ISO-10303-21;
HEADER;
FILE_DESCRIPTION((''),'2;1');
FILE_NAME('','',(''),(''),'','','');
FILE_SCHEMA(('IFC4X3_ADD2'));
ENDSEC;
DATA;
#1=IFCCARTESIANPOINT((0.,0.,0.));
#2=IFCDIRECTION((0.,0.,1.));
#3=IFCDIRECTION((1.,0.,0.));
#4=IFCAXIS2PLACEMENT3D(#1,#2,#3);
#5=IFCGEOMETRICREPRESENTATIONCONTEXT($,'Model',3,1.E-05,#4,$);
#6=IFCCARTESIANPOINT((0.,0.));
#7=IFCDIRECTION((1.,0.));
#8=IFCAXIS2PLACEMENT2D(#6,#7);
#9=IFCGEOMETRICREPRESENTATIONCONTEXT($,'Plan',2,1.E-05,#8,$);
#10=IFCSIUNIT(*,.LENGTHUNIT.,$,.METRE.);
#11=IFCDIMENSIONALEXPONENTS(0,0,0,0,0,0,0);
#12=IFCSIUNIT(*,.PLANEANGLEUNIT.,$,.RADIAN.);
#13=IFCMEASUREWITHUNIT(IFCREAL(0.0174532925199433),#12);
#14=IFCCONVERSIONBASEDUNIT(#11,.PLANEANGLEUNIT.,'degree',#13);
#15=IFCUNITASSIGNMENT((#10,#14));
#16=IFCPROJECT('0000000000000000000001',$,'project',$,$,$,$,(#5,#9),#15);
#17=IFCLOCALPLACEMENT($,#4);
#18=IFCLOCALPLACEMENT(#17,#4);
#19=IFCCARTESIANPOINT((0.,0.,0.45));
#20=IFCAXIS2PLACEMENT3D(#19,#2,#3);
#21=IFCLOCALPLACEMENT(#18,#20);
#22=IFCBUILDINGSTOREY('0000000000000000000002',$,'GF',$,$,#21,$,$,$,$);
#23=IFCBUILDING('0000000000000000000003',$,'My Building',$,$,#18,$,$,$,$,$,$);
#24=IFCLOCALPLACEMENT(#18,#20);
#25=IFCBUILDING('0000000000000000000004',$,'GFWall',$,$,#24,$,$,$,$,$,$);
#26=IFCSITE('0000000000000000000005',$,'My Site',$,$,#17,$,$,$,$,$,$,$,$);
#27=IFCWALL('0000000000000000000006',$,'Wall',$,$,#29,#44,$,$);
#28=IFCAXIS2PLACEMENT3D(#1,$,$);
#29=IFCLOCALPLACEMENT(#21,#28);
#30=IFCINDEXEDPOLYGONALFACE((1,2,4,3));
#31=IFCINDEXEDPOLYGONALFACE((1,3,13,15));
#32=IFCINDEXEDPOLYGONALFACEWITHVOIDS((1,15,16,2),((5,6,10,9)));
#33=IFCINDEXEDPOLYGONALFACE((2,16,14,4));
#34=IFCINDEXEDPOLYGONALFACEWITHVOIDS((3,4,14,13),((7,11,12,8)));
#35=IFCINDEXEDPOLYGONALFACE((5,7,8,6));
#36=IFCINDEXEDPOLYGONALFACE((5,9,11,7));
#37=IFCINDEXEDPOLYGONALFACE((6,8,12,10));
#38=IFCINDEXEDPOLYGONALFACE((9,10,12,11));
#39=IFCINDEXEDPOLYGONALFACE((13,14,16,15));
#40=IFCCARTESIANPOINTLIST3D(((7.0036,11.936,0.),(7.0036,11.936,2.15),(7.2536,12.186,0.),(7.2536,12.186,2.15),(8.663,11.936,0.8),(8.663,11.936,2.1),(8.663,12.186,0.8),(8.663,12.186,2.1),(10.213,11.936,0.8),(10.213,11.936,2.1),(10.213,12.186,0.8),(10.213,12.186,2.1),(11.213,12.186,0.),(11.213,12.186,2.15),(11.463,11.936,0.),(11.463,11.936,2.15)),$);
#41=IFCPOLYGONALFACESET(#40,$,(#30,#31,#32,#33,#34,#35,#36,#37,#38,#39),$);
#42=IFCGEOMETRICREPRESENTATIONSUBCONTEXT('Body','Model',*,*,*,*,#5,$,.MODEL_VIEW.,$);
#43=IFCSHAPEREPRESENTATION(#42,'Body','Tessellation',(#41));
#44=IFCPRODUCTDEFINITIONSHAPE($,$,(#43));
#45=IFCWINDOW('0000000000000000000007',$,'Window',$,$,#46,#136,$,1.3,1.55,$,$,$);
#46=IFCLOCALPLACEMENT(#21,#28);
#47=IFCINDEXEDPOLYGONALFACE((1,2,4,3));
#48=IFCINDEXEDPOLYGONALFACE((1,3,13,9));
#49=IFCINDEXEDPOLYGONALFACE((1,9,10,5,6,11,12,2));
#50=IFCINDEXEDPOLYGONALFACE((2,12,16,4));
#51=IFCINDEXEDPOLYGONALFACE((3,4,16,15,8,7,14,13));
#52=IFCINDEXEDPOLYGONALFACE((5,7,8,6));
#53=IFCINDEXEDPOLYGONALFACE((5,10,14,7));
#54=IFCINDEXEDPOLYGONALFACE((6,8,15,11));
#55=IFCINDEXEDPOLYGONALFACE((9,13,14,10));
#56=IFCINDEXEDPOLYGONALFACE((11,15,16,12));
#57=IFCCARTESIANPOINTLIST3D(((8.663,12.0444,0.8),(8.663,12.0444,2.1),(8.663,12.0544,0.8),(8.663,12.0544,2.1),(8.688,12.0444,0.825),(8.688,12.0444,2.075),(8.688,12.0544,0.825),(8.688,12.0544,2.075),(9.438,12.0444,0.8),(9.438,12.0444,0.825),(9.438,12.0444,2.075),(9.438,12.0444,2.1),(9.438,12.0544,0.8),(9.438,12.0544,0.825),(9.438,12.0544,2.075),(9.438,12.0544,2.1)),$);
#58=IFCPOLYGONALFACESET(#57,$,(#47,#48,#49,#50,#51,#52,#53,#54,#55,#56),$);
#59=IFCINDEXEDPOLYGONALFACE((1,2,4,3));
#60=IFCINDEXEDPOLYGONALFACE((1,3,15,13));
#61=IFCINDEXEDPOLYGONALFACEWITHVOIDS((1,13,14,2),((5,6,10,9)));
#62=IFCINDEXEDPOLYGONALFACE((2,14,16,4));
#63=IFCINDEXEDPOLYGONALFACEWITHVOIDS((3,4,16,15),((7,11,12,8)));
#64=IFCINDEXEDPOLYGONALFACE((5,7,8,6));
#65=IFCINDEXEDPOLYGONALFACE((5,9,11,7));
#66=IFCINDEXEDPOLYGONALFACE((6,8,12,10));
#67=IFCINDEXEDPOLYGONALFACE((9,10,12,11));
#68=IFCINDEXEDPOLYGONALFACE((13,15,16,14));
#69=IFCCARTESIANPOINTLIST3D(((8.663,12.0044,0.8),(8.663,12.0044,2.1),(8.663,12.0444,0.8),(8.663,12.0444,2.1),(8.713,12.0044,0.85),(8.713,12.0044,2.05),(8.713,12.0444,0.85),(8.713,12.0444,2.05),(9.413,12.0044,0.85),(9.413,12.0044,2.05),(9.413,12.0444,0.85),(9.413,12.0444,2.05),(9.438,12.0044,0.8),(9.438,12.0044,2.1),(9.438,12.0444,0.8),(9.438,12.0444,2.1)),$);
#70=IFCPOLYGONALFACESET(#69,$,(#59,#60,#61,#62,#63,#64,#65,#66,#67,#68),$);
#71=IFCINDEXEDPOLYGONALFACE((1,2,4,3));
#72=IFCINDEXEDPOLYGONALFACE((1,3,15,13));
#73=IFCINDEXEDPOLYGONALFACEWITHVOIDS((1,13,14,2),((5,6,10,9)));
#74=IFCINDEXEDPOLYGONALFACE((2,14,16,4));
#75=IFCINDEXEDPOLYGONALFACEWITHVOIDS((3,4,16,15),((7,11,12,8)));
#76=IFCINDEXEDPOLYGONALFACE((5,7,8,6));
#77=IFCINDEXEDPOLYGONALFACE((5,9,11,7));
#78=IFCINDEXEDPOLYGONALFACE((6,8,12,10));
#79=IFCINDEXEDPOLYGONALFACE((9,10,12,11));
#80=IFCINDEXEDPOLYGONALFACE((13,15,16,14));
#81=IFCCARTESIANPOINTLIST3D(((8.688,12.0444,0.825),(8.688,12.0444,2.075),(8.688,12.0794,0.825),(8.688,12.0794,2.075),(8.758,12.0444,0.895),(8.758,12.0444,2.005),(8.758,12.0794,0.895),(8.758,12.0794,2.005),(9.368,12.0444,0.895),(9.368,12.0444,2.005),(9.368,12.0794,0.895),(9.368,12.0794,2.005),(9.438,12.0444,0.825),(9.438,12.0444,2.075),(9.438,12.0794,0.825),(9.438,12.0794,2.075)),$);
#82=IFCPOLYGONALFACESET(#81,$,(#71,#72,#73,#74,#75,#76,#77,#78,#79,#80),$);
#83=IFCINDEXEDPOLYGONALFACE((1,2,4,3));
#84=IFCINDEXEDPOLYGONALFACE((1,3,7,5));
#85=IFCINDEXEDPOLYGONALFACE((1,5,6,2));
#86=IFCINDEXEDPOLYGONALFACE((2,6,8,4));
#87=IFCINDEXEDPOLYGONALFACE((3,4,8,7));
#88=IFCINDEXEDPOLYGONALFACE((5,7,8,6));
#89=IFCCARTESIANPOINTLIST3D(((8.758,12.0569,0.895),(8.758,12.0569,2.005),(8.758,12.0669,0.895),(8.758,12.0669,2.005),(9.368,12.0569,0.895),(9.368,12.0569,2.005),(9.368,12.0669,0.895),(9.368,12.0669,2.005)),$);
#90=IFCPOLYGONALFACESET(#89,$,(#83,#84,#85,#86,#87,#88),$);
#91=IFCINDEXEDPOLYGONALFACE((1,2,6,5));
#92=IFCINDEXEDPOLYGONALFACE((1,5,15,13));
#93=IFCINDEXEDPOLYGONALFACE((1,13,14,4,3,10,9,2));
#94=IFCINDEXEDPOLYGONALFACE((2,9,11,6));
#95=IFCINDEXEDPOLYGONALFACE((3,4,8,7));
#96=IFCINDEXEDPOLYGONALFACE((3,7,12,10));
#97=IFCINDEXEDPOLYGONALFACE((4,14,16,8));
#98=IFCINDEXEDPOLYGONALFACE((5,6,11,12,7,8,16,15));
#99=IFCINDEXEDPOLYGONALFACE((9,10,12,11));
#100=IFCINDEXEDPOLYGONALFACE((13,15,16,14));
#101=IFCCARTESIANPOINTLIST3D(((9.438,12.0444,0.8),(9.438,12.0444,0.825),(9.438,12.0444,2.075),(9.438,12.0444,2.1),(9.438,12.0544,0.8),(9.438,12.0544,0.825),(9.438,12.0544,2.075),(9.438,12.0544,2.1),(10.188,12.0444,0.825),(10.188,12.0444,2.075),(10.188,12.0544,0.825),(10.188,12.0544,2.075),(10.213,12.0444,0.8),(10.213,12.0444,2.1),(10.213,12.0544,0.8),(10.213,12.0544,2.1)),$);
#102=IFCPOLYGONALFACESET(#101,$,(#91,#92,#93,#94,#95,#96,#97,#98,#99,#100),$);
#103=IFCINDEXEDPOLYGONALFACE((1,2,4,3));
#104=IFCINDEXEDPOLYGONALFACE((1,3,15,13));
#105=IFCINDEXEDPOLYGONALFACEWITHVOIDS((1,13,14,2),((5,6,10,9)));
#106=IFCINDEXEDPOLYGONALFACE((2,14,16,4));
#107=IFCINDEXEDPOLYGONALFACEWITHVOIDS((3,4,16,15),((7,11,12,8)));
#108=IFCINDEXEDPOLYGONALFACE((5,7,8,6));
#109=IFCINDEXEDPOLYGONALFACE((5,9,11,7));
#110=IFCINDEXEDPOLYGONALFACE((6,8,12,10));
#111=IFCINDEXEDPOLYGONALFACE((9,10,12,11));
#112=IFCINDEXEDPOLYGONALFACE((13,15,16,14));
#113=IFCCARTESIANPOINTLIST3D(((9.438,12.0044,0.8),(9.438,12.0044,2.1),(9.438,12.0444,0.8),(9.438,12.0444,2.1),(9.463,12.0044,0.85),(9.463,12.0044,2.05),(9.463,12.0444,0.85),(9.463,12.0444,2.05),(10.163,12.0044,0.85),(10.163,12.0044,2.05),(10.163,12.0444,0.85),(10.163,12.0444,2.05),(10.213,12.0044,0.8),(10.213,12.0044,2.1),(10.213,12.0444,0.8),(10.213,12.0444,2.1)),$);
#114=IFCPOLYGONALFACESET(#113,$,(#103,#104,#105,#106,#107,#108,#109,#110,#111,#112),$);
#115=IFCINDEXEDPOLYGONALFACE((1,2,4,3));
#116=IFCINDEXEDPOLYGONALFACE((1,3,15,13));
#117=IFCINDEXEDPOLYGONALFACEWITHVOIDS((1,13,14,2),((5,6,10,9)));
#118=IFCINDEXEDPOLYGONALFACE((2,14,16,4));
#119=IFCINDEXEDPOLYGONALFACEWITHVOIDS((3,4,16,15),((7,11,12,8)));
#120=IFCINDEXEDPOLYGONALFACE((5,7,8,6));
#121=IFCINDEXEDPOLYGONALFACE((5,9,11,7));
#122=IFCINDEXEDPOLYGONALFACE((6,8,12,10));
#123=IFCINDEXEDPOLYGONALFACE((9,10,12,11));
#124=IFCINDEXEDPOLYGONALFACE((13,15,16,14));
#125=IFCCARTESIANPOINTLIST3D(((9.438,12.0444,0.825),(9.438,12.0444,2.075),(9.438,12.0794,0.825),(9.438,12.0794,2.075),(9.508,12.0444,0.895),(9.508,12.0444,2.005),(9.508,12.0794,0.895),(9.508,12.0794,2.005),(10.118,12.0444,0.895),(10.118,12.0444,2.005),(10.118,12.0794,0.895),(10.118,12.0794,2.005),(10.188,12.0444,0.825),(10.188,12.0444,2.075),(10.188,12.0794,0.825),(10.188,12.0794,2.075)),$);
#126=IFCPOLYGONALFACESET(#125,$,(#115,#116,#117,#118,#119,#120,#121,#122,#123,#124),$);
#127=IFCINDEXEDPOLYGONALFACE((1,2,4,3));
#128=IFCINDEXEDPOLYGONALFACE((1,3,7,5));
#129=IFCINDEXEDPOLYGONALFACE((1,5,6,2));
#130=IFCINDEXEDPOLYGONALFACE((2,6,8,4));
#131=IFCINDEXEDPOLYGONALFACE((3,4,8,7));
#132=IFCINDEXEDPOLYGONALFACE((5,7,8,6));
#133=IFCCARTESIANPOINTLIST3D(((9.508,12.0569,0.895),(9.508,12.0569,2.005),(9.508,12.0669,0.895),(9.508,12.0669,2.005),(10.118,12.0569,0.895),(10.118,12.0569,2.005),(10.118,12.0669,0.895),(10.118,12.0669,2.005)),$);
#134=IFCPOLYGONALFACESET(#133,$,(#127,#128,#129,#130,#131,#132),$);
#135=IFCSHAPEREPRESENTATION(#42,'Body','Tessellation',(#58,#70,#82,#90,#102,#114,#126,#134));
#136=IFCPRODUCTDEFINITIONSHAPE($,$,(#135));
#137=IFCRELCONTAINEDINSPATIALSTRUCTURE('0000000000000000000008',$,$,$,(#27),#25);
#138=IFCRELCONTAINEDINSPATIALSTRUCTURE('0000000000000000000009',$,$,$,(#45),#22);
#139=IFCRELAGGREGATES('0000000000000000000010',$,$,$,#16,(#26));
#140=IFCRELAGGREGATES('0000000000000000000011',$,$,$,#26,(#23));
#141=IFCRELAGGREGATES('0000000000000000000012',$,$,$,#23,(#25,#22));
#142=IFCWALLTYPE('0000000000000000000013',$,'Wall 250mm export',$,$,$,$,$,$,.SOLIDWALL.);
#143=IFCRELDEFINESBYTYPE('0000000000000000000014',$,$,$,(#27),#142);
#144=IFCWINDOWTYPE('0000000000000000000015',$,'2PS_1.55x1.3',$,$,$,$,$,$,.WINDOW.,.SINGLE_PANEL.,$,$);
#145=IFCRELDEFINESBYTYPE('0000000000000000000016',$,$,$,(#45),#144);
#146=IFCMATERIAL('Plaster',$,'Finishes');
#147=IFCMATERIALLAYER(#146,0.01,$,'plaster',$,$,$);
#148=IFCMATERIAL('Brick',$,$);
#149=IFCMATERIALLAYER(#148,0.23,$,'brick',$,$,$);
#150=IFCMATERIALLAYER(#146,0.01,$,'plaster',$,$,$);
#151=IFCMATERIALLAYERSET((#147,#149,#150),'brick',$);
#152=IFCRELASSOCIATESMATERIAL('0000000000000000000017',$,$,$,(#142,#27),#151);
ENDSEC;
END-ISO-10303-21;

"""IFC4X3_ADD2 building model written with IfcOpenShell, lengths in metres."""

from ifc_helpers import new_model, entity, si_unit, converted_unit, frame, origin_with_axes, origin_2d_with_axis, place, context, subcontext, project, spatial, line, indexed_curve, outline, extrude, shape, source, transform, mapped, material, layer, layer_set, layer_usage, type_object, type_shapes, element, fill, save


model = new_model("IFC4X3_ADD2")

# Units and contexts
model_context = context("Model", 3, precision=1e-05, world=origin_with_axes())
plan_context = context("Plan", 2, precision=1e-05, world=origin_2d_with_axis())
body_context_1 = subcontext(model_context, "Body", "Model", "MODEL_VIEW")
body_context_2 = subcontext(plan_context, "Body", "Plan", "PLAN_VIEW")
ifc_project = project(units=[si_unit("LENGTHUNIT", "METRE"), converted_unit("PLANEANGLEUNIT", "degree", entity("IfcReal", 0.0174532925199433), si_unit("PLANEANGLEUNIT", "RADIAN"), dimensions=[0, 0, 0, 0, 0, 0, 0])], contexts=[model_context, plan_context])

# Site, buildings
site_placement = place(None, origin_with_axes())
site = spatial("IfcSite", under=ifc_project, at=site_placement, Name="My Site")
building_1_placement = place(site_placement, origin_with_axes())
building_1 = spatial("IfcBuilding", under=site, at=building_1_placement, Name="My Building")
building_2_placement = place(building_1_placement, frame((0.0, 0.0, 0.45), z_axis=(0.0, 0.0, 1.0), x_axis=(1.0, 0.0, 0.0)))
building_2 = spatial("IfcBuilding", under=building_1, at=building_2_placement, Name="GFWall")

# Shared definitions
ifc_material_1 = material(Name="Plaster", Category="Finishes")

# Shared definitions
storey_placement = place(building_1_placement, frame((0.0, 0.0, 0.45), z_axis=(0.0, 0.0, 1.0), x_axis=(1.0, 0.0, 0.0)))
storey = spatial("IfcBuildingStorey", under=building_1, at=storey_placement, Name="GF")

# Shared definitions
ifc_layer_1 = layer(ifc_material_1, 0.01, Name="plaster")
ifc_material_2 = material(Name="Brick")
ifc_layer_2 = layer(ifc_material_2, 0.23, Name="brick")
ifc_layer_3 = layer(ifc_material_1, 0.01, Name="plaster")
ifc_layer_set_1 = layer_set([ifc_layer_1, ifc_layer_2, ifc_layer_3], Name="brick")
wall_type_1 = type_object("IfcWallType", Name="Wall 250mm export", PredefinedType="SOLIDWALL", material=ifc_layer_set_1)

# Wall, opening, window
shared_shape_1 = source(origin_with_axes(), body_context_1, "Body", "SweptSolid", [
    extrude(outline(indexed_curve([(0.0, 0.0), (1.55, 0.0), (1.55, 1.3), (0.0, 1.3)], segments=[line(1, 2, 3, 4, 1)])), frame((0.0, -0.6, 0.0), z_axis=(0.0, -1.0, 0.0), x_axis=(1.0, 0.0, 0.0)), (0.0, 0.0, -1.0), 1.2),
])
window_type_1 = type_object("IfcWindowType", Name="2PS_1.55x1.3", PartitioningType="SINGLE_PANEL", PredefinedType="WINDOW")
shared_shape_2 = source(origin_with_axes(), body_context_1, "Body", "SweptSolid", [
    extrude(outline(indexed_curve([(0.775, 0.0), (0.0, 0.0), (0.0, 1.3), (0.775, 1.3), (0.775, 1.275), (0.025, 1.275), (0.025, 0.025), (0.775, 0.025)], segments=[line(1, 2, 3, 4, 5, 6, 7, 8, 1)])), frame((0.0, 0.09, 0.0), z_axis=(0.0, -1.0, 0.0), x_axis=(1.0, 0.0, 0.0)), (0.0, 0.0, -1.0), 0.01),
    extrude(outline(indexed_curve([(0.0, 0.0), (0.775, 0.0), (0.775, 1.3), (0.0, 1.3)], segments=[line(1, 2, 3, 4, 1)]), holes=[indexed_curve([(0.05, 0.05), (0.75, 0.05), (0.75, 1.25), (0.05, 1.25)], segments=[line(1, 2, 3, 4, 1)])]), frame((0.0, 0.05, 0.0), z_axis=(0.0, -1.0, 0.0), x_axis=(1.0, 0.0, 0.0)), (0.0, 0.0, -1.0), 0.04),
    extrude(outline(indexed_curve([(0.0, 0.0), (0.75, 0.0), (0.75, 1.25), (0.0, 1.25)], segments=[line(1, 2, 3, 4, 1)]), holes=[indexed_curve([(0.07, 0.07), (0.68, 0.07), (0.68, 1.18), (0.07, 1.18)], segments=[line(1, 2, 3, 4, 1)])]), frame((0.025, 0.09, 0.025), z_axis=(0.0, -1.0, 0.0), x_axis=(1.0, 0.0, 0.0)), (0.0, 0.0, -1.0), 0.035),
    extrude(outline(indexed_curve([(0.07, 0.07), (0.68, 0.07), (0.68, 1.18), (0.07, 1.18)], segments=[line(1, 2, 3, 4, 1)])), frame((0.025, 0.1025, 0.025), z_axis=(0.0, -1.0, 0.0), x_axis=(1.0, 0.0, 0.0)), (0.0, 0.0, -1.0), 0.01),
    extrude(outline(indexed_curve([(0.0, 1.3), (0.775, 1.3), (0.775, 0.0), (0.0, 0.0), (0.0, 0.025), (0.75, 0.025), (0.75, 1.275), (0.0, 1.275)], segments=[line(1, 2, 3, 4, 5, 6, 7, 8, 1)])), frame((0.775, 0.09, 0.0), z_axis=(0.0, -1.0, 0.0), x_axis=(1.0, 0.0, 0.0)), (0.0, 0.0, -1.0), 0.01),
    extrude(outline(indexed_curve([(0.0, 0.0), (0.775, 0.0), (0.775, 1.3), (0.0, 1.3)], segments=[line(1, 2, 3, 4, 1)]), holes=[indexed_curve([(0.025, 0.05), (0.725, 0.05), (0.725, 1.25), (0.025, 1.25)], segments=[line(1, 2, 3, 4, 1)])]), frame((0.775, 0.05, 0.0), z_axis=(0.0, -1.0, 0.0), x_axis=(1.0, 0.0, 0.0)), (0.0, 0.0, -1.0), 0.04),
    extrude(outline(indexed_curve([(0.0, 0.0), (0.75, 0.0), (0.75, 1.25), (0.0, 1.25)], segments=[line(1, 2, 3, 4, 1)]), holes=[indexed_curve([(0.07, 0.07), (0.68, 0.07), (0.68, 1.18), (0.07, 1.18)], segments=[line(1, 2, 3, 4, 1)])]), frame((0.775, 0.09, 0.025), z_axis=(0.0, -1.0, 0.0), x_axis=(1.0, 0.0, 0.0)), (0.0, 0.0, -1.0), 0.035),
    extrude(outline(indexed_curve([(0.07, 0.07), (0.68, 0.07), (0.68, 1.18), (0.07, 1.18)], segments=[line(1, 2, 3, 4, 1)])), frame((0.775, 0.1025, 0.025), z_axis=(0.0, -1.0, 0.0), x_axis=(1.0, 0.0, 0.0)), (0.0, 0.0, -1.0), 0.01),
])
shared_shape_3 = source(origin_with_axes(), body_context_2, "Body", "Curve2D", [
    entity("IfcIndexedPolyCurve", entity("IfcCartesianPointList2D", [[0.05, 0.05], [0.75, 0.05]])),
    entity("IfcIndexedPolyCurve", entity("IfcCartesianPointList2D", [[0.0, 0.1], [0.025, 0.1], [0.025, 0.09], [0.05, 0.09], [0.05, 0.05], [0.0, 0.05]]), [entity("IfcLineIndex", [1, 2, 3, 4, 5, 6, 1])]),
    entity("IfcIndexedPolyCurve", entity("IfcCartesianPointList2D", [[0.775, 0.1], [0.775, 0.1], [0.775, 0.09], [0.75, 0.09], [0.75, 0.05], [0.775, 0.05]])),
    entity("IfcIndexedPolyCurve", entity("IfcCartesianPointList2D", [[0.025, 0.09], [0.095, 0.09], [0.095, 0.125], [0.025, 0.125]]), [entity("IfcLineIndex", [1, 2, 3, 4, 1])]),
    entity("IfcIndexedPolyCurve", entity("IfcCartesianPointList2D", [[0.775, 0.09], [0.705, 0.09], [0.705, 0.125], [0.775, 0.125]]), [entity("IfcLineIndex", [1, 2, 3, 4, 1])]),
    entity("IfcIndexedPolyCurve", entity("IfcCartesianPointList2D", [[0.095, 0.09], [0.705, 0.09]])),
    entity("IfcIndexedPolyCurve", entity("IfcCartesianPointList2D", [[0.095, 0.125], [0.705, 0.125]])),
    entity("IfcIndexedPolyCurve", entity("IfcCartesianPointList2D", [[0.095, 0.1075], [0.705, 0.1075]])),
    entity("IfcIndexedPolyCurve", entity("IfcCartesianPointList2D", [[0.8, 0.05], [1.5, 0.05]])),
    entity("IfcIndexedPolyCurve", entity("IfcCartesianPointList2D", [[0.775, 0.1], [0.775, 0.1], [0.775, 0.09], [0.8, 0.09], [0.8, 0.05], [0.775, 0.05]])),
    entity("IfcIndexedPolyCurve", entity("IfcCartesianPointList2D", [[1.55, 0.1], [1.525, 0.1], [1.525, 0.09], [1.5, 0.09], [1.5, 0.05], [1.55, 0.05]]), [entity("IfcLineIndex", [1, 2, 3, 4, 5, 6, 1])]),
    entity("IfcIndexedPolyCurve", entity("IfcCartesianPointList2D", [[0.775, 0.09], [0.845, 0.09], [0.845, 0.125], [0.775, 0.125]]), [entity("IfcLineIndex", [1, 2, 3, 4, 1])]),
    entity("IfcIndexedPolyCurve", entity("IfcCartesianPointList2D", [[1.525, 0.09], [1.455, 0.09], [1.455, 0.125], [1.525, 0.125]]), [entity("IfcLineIndex", [1, 2, 3, 4, 1])]),
    entity("IfcIndexedPolyCurve", entity("IfcCartesianPointList2D", [[0.845, 0.09], [1.455, 0.09]])),
    entity("IfcIndexedPolyCurve", entity("IfcCartesianPointList2D", [[0.845, 0.125], [1.455, 0.125]])),
    entity("IfcIndexedPolyCurve", entity("IfcCartesianPointList2D", [[0.845, 0.1075], [1.455, 0.1075]])),
])
type_shapes(window_type_1, [shared_shape_2, shared_shape_3])
ifc_layer_usage_1 = layer_usage(ifc_layer_set_1, "AXIS2", "POSITIVE", 0.0)
wall_1_placement = place(building_2_placement, frame((7.2536, 11.936, 0.0), z_axis=(0.0, 0.0, 1.0), x_axis=(1.0, 0.0, 0.0)))
wall_1 = element("IfcWall", 1, at=wall_1_placement, inside=building_2, type_object=wall_type_1, material=ifc_layer_usage_1, Name="Wall", context=body_context_1, shape_type="SweptSolid", body=[
    extrude(outline(indexed_curve([(-0.25, 0.0), (0.0, 0.25), (3.9594, 0.25), (4.2094, 0.0)], segments=[line(1, 2, 3, 4, 1)])), origin_with_axes(), (0.0, 0.0, 1.0), 2.15),
])
opening_1_placement = place(wall_1_placement, frame((1.4094, 0.0184, 0.8), z_axis=(0.0, 0.0, 1.0), x_axis=(1.0, 0.0, 0.0)))
opening_1 = element("IfcOpeningElement", 2, at=opening_1_placement, cuts=wall_1, PredefinedType="OPENING", context=body_context_1, shape_type="MappedRepresentation", body=[
    mapped(shared_shape_1, transform((0.0, 0.0, 0.0), x_axis=(1.0, 0.0, 0.0), y_axis=(0.0, 1.0, 0.0), z_axis=(0.0, 0.0, 1.0), scale=1.0)),
])
window_1_placement = place(opening_1_placement, origin_with_axes())
window_1 = element("IfcWindow", 3, at=window_1_placement, inside=storey, type_object=window_type_1, Name="Window", OverallHeight=1.3, OverallWidth=1.55, shapes=[
    shape(body_context_1, "Body", "MappedRepresentation", [mapped(shared_shape_2, transform((0.0, 0.0, 0.0), x_axis=(1.0, 0.0, 0.0), y_axis=(0.0, 1.0, 0.0), z_axis=(0.0, 0.0, 1.0), scale=1.0))]),
    shape(body_context_2, "Body", "MappedRepresentation", [mapped(shared_shape_3, transform((0.0, 0.0, 0.0), x_axis=(1.0, 0.0, 0.0), y_axis=(0.0, 1.0, 0.0), z_axis=(0.0, 0.0, 1.0), scale=1.0))]),
])
fill(opening_1, window_1)

save(model, "model.ifc")
